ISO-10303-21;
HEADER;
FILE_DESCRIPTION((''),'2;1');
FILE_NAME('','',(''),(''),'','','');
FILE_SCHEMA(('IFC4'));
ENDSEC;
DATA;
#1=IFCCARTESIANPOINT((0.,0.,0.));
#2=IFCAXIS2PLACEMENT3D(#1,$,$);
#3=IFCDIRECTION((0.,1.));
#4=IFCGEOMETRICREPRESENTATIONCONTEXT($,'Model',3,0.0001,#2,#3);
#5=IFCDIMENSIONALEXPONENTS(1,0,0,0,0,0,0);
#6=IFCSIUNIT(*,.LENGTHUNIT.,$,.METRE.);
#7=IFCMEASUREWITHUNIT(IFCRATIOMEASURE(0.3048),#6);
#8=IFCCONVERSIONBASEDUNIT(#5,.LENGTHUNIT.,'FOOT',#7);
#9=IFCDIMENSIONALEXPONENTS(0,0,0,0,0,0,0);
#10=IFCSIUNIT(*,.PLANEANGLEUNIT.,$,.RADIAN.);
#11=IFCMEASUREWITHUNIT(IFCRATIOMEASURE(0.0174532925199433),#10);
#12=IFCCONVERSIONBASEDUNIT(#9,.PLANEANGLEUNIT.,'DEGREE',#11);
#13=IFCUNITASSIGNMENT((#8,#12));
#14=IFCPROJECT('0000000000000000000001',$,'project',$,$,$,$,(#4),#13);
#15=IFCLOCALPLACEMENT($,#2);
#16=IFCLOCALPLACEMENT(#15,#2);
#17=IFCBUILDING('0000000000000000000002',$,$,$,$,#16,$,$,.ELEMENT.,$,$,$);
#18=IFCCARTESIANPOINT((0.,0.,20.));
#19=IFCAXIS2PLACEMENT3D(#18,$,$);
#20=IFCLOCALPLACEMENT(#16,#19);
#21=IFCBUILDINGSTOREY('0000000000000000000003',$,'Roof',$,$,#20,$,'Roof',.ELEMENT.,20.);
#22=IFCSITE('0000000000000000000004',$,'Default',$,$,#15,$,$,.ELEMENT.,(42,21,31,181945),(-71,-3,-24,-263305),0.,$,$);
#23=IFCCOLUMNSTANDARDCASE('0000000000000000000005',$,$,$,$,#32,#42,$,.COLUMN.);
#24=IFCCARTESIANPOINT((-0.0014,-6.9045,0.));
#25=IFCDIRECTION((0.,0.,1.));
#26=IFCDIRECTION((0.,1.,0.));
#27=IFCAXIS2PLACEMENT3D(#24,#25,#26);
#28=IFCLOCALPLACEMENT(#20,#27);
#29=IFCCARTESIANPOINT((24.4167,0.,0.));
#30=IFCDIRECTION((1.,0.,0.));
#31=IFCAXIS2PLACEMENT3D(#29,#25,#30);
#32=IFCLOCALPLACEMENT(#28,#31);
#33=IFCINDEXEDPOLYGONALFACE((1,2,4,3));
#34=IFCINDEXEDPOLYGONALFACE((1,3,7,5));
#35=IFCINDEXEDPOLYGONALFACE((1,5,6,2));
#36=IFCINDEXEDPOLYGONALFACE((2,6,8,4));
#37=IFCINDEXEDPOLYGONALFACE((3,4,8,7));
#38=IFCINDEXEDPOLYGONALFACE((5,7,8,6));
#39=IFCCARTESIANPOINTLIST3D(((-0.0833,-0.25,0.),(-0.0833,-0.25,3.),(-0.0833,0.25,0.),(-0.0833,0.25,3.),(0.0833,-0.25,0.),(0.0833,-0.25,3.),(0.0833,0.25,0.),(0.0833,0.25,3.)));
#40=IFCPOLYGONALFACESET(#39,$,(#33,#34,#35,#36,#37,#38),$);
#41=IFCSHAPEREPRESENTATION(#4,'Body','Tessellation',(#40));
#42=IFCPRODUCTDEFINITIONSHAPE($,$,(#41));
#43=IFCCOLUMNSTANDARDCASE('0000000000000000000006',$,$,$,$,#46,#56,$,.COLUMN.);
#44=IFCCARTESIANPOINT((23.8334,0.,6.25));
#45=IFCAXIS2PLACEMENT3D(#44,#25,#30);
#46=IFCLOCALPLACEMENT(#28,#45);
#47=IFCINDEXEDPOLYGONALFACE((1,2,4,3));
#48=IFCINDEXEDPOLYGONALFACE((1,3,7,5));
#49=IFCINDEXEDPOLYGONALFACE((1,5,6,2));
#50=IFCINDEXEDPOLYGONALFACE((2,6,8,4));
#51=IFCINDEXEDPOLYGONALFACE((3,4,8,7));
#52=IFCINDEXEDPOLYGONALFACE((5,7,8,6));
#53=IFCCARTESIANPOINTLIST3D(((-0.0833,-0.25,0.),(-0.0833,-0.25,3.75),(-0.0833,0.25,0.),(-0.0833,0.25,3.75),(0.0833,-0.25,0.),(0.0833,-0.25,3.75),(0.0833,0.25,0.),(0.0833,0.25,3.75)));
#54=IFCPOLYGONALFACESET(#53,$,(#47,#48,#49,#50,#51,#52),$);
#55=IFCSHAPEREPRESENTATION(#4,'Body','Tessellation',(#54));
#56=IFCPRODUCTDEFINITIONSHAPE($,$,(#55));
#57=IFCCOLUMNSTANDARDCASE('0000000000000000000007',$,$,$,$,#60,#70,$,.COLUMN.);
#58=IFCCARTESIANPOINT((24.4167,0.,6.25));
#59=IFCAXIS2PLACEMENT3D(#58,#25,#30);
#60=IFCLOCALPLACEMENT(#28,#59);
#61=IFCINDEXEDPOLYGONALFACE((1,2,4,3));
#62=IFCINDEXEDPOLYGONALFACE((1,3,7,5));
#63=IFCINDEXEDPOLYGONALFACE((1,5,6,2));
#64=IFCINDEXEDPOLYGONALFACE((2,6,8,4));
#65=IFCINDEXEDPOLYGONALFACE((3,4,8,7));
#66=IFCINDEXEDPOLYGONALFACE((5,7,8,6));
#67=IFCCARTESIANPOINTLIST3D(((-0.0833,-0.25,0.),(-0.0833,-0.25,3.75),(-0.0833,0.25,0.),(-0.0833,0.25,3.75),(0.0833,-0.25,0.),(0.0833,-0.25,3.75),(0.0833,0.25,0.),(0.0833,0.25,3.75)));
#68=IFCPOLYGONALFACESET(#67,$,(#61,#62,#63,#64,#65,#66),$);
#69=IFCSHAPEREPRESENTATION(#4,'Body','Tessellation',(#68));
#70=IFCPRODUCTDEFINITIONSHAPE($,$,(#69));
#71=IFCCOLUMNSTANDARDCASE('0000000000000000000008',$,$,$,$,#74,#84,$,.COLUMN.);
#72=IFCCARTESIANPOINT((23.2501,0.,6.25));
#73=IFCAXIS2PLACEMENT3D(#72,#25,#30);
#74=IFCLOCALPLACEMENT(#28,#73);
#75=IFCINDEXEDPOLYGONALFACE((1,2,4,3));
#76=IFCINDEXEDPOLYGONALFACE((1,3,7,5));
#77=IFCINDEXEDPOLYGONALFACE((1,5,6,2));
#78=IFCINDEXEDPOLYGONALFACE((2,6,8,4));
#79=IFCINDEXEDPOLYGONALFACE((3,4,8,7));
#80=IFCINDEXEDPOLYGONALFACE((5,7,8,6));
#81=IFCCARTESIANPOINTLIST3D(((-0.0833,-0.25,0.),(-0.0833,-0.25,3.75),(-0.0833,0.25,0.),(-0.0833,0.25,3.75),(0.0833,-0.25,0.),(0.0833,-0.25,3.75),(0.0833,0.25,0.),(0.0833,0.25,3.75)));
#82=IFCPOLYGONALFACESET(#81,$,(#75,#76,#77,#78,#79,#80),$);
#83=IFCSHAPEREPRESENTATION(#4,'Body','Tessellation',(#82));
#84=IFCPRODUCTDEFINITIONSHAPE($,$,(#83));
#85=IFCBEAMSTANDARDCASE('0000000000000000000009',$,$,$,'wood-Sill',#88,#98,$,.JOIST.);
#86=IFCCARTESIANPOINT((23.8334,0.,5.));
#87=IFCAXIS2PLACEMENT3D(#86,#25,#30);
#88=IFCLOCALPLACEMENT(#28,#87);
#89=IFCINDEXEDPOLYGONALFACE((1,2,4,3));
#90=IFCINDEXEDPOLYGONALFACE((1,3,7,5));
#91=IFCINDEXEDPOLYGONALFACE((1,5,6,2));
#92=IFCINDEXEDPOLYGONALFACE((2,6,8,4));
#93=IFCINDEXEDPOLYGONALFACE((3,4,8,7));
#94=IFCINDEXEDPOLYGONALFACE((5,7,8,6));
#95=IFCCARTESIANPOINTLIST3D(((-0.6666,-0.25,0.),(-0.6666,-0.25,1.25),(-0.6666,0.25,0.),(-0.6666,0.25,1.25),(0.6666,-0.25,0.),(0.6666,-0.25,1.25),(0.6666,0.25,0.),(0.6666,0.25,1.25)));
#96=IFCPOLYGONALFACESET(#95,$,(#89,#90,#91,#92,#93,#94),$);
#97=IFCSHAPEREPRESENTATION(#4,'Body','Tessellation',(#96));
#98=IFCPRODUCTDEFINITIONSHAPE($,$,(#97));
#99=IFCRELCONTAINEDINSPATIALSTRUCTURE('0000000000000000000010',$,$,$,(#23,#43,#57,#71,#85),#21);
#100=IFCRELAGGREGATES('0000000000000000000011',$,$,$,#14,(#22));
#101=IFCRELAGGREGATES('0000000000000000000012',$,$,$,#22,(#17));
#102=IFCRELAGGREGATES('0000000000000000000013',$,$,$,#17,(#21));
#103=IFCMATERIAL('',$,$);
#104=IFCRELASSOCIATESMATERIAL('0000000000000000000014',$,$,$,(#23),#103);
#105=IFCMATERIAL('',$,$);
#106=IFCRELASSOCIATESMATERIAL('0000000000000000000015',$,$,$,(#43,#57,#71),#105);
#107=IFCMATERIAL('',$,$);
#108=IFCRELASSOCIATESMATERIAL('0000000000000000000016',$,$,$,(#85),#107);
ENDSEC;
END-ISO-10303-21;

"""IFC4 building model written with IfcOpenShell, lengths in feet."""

from ifc_helpers import new_model, entity, si_unit, converted_unit, direction, frame, origin, place, context, project, spatial, rectangle, extrude, material, element, save


model = new_model("IFC4")

# Units and contexts
model_context = context("Model", 3, precision=0.0001, world=origin(), true_north=direction((0.0, 1.0)))
ifc_project = project(units=[converted_unit("LENGTHUNIT", "FOOT", entity("IfcRatioMeasure", 0.3048), si_unit("LENGTHUNIT", "METRE"), dimensions=[1, 0, 0, 0, 0, 0, 0]), converted_unit("PLANEANGLEUNIT", "DEGREE", entity("IfcRatioMeasure", 0.0174532925199433), si_unit("PLANEANGLEUNIT", "RADIAN"), dimensions=[0, 0, 0, 0, 0, 0, 0])], contexts=[model_context])

# Site, building, storey
site_placement = place(None, origin())
site = spatial("IfcSite", under=ifc_project, at=site_placement, Name="Default", CompositionType="ELEMENT", RefLatitude=(42, 21, 31, 181945), RefLongitude=(-71, -3, -24, -263305), RefElevation=0.0)
building_placement = place(site_placement, origin())
building = spatial("IfcBuilding", under=site, at=building_placement, CompositionType="ELEMENT")
storey_placement = place(building_placement, frame((0.0, 0.0, 20.0)))
storey = spatial("IfcBuildingStorey", under=building, at=storey_placement, Name="Roof", LongName="Roof", CompositionType="ELEMENT", Elevation=20.0)

# Columns
placement_1 = place(storey_placement, frame((-0.0014, -6.9045, 0.0), z_axis=(0.0, 0.0, 1.0), x_axis=(0.0, 1.0, 0.0)))
ifc_material_1 = material(Name="")
for number, where, z_axis, x_axis in (
    (1, (24.4167, 0.0, 0.0), (0.0, 0.0, 1.0), (1.0, 0.0, 0.0)),
):
    element("IfcColumnStandardCase", number, at=place(placement_1, frame(where, z_axis=z_axis, x_axis=x_axis)), inside=storey, material=ifc_material_1, PredefinedType="COLUMN", context=model_context, shape_type="SweptSolid", body=[
        extrude(rectangle(XDim=0.1667, YDim=0.5), origin(), (0.0, 0.0, 1.0), 3.0),
    ])
ifc_material_2 = material(Name="")
for number, where, z_axis, x_axis in (
    (2, (23.8334, 0.0, 6.25), (0.0, 0.0, 1.0), (1.0, 0.0, 0.0)),
    (3, (24.4167, 0.0, 6.25), (0.0, 0.0, 1.0), (1.0, 0.0, 0.0)),
    (4, (23.2501, 0.0, 6.25), (0.0, 0.0, 1.0), (1.0, 0.0, 0.0)),
):
    element("IfcColumnStandardCase", number, at=place(placement_1, frame(where, z_axis=z_axis, x_axis=x_axis)), inside=storey, material=ifc_material_2, PredefinedType="COLUMN", context=model_context, shape_type="SweptSolid", body=[
        extrude(rectangle(XDim=0.1667, YDim=0.5), origin(), (0.0, 0.0, 1.0), 3.75),
    ])

# Beam
ifc_material_3 = material(Name="")
for number, where, z_axis, x_axis in (
    (5, (23.8334, 0.0, 5.0), (0.0, 0.0, 1.0), (1.0, 0.0, 0.0)),
):
    element("IfcBeamStandardCase", number, at=place(placement_1, frame(where, z_axis=z_axis, x_axis=x_axis)), inside=storey, material=ifc_material_3, ObjectType="wood-Sill", PredefinedType="JOIST", context=model_context, shape_type="SweptSolid", body=[
        extrude(rectangle(XDim=1.3333, YDim=0.5), origin(), (0.0, 0.0, 1.0), 1.25),
    ])

save(model, "model.ifc")
